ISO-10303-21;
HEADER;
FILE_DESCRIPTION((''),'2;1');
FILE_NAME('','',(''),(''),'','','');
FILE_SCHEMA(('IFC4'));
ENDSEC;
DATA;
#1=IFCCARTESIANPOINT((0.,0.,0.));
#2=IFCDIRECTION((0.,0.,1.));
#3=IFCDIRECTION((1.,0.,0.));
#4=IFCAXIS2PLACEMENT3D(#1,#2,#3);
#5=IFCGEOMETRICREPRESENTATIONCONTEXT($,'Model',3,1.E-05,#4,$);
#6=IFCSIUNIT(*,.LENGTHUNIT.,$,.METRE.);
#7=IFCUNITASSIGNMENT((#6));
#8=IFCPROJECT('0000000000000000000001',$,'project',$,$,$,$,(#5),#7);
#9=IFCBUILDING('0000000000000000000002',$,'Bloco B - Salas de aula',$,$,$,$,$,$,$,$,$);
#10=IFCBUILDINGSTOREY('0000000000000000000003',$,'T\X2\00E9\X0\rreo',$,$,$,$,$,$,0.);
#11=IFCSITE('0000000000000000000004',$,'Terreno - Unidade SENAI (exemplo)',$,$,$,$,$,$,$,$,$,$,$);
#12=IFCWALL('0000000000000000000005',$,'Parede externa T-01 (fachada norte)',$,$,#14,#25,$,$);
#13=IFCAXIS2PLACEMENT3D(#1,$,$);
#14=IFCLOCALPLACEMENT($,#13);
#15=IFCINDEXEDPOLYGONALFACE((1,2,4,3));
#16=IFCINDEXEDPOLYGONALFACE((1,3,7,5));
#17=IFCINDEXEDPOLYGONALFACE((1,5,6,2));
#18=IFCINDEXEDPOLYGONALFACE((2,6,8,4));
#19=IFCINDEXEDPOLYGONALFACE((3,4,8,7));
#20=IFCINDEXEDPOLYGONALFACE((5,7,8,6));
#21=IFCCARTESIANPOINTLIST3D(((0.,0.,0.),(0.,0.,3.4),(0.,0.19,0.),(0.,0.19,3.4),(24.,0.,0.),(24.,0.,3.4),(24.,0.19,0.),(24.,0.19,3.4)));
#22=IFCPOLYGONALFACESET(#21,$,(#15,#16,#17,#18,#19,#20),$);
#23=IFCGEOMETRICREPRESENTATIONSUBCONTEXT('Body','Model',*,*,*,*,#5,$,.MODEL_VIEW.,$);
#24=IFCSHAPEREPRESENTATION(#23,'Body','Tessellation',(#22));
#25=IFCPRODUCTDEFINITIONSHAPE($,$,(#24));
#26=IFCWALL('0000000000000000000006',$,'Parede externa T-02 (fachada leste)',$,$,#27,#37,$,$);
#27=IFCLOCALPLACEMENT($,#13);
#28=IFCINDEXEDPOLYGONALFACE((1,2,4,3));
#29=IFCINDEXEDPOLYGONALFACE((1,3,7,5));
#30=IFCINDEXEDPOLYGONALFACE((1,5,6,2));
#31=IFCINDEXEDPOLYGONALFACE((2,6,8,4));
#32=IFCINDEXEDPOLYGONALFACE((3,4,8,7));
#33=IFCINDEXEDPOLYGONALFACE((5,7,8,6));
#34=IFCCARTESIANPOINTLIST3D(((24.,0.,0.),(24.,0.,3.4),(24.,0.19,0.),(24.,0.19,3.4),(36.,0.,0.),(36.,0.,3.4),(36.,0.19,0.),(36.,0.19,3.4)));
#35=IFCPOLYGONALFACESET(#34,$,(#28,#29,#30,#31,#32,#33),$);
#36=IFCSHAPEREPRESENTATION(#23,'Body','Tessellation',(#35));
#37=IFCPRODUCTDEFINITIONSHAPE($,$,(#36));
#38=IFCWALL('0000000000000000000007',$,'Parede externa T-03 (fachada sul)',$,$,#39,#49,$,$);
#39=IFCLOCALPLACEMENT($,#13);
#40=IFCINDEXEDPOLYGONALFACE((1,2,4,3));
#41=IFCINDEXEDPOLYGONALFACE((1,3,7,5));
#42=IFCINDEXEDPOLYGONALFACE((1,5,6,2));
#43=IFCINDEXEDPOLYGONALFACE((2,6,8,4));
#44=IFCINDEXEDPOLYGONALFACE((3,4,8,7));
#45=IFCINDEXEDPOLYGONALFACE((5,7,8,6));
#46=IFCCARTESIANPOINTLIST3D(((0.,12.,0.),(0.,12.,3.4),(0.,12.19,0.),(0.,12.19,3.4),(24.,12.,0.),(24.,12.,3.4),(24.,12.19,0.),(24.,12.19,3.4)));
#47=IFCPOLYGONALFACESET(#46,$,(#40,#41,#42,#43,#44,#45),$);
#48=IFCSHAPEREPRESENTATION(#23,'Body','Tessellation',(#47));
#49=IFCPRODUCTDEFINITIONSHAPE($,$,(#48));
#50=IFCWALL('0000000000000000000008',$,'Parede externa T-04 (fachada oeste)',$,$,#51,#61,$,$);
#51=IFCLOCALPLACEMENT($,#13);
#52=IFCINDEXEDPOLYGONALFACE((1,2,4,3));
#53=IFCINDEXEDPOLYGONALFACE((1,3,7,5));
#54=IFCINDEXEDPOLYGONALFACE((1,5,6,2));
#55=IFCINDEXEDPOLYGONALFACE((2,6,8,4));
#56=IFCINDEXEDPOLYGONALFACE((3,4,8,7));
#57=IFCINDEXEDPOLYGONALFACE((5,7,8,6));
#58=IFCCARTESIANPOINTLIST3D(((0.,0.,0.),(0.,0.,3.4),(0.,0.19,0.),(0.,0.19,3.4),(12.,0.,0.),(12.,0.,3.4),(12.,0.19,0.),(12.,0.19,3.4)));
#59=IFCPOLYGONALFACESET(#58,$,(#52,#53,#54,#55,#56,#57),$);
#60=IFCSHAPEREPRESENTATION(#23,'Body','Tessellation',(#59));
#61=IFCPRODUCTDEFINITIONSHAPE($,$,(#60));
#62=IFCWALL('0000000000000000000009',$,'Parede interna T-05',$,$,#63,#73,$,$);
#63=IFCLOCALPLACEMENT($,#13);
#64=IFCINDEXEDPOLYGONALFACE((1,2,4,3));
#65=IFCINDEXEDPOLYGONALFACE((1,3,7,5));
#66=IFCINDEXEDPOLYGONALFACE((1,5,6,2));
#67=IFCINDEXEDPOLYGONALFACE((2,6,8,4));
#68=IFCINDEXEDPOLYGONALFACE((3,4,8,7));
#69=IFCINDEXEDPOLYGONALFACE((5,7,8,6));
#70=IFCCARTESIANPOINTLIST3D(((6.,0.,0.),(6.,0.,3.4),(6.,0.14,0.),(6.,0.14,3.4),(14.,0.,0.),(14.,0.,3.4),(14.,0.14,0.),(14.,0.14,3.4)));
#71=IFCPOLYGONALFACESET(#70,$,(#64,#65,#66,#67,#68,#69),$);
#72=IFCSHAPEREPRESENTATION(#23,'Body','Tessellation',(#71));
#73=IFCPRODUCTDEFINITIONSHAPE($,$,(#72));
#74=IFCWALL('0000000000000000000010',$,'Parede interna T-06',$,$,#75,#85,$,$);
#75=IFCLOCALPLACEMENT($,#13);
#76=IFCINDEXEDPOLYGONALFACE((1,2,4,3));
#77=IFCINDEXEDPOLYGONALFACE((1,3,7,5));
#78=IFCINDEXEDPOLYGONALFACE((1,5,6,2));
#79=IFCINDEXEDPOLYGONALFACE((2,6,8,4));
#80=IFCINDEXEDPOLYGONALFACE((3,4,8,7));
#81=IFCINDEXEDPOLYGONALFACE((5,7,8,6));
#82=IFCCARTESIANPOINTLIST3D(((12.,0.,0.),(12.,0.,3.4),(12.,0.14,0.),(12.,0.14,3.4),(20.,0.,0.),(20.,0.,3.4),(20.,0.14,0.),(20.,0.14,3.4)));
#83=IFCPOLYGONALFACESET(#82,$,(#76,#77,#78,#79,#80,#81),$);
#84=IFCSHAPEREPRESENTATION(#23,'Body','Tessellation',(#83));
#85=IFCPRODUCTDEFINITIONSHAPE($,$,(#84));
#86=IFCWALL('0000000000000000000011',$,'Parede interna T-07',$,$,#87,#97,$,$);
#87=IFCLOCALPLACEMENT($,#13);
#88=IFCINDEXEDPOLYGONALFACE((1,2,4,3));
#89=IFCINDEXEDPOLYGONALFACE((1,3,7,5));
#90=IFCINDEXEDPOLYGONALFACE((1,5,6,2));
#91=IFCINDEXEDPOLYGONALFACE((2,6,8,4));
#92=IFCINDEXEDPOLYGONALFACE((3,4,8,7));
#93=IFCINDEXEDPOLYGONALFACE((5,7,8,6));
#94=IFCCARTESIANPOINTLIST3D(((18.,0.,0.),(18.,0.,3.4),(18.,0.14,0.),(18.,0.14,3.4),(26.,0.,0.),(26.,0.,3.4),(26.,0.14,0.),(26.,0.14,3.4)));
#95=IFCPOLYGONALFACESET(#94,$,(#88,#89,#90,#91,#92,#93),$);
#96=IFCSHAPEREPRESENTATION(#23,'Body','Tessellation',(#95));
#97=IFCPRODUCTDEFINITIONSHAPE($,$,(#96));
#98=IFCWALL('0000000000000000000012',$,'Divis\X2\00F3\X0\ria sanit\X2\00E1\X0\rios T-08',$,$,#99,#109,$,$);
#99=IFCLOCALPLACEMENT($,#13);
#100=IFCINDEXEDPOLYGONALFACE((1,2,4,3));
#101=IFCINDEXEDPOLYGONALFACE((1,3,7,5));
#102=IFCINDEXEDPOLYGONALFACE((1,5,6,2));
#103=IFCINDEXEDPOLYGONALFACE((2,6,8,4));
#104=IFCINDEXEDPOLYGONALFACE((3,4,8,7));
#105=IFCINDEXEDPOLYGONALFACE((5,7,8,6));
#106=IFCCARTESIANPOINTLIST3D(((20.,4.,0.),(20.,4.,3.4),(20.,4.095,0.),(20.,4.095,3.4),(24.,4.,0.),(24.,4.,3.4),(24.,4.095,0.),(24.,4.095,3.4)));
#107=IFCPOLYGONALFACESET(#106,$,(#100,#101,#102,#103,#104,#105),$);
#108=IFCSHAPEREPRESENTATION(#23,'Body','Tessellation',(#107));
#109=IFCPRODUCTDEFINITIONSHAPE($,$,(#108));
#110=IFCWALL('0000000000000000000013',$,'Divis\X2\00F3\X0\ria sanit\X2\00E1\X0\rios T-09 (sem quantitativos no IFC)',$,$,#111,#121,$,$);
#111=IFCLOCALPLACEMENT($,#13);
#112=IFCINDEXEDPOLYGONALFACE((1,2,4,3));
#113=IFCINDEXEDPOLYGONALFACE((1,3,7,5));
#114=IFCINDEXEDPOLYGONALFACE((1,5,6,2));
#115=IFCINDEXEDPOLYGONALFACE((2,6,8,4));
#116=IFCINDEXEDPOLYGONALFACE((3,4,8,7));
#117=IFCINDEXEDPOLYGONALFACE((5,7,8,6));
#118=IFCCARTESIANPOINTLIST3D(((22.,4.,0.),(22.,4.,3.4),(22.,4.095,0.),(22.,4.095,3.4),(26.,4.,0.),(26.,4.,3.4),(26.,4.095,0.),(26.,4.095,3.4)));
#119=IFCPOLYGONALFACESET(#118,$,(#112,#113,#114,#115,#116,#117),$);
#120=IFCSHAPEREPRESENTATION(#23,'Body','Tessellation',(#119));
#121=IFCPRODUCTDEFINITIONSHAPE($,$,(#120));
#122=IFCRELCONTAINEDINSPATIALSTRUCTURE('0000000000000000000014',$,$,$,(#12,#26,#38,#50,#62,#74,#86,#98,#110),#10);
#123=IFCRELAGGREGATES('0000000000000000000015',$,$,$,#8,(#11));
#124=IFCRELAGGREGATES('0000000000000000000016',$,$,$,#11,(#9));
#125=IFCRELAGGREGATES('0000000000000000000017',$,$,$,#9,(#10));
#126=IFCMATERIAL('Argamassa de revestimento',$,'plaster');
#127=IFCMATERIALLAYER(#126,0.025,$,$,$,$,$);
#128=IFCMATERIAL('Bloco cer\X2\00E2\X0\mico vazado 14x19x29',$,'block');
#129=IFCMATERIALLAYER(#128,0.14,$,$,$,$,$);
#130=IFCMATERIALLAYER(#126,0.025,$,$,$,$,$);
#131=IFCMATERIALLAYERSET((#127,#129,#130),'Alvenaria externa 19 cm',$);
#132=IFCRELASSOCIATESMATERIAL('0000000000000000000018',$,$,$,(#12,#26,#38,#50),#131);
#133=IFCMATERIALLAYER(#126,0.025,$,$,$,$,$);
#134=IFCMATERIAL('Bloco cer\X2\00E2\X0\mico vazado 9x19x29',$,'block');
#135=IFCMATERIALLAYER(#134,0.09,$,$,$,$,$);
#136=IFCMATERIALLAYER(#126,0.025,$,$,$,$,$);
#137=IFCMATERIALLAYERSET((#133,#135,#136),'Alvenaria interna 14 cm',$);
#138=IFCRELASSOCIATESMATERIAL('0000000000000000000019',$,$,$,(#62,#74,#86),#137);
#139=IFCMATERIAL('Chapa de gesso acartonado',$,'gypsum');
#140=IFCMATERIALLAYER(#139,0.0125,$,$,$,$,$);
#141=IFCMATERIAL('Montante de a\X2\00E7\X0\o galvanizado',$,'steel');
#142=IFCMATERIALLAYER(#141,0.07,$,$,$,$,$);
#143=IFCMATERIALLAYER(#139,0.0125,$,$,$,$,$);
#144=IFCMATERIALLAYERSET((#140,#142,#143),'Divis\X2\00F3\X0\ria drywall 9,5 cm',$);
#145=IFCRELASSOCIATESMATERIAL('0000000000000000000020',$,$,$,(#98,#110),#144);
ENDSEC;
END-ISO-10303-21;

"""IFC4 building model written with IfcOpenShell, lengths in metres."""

from ifc_helpers import new_model, si_unit, frame, origin_with_axes, place, context, subcontext, project, spatial, indexed_curve, outline, extrude, material, layer, layer_set, layer_usage, element, save


model = new_model("IFC4")

# Units and contexts
model_context = context("Model", 3, precision=1e-05, world=origin_with_axes())
body_context = subcontext(model_context, "Body", "Model", "MODEL_VIEW")
ifc_project = project(units=[si_unit("LENGTHUNIT", "METRE")], contexts=[model_context])

# Site, building, storey
site = spatial("IfcSite", under=ifc_project, Name="Terreno - Unidade SENAI (exemplo)")
building = spatial("IfcBuilding", under=site, Name="Bloco B - Salas de aula")
storey = spatial("IfcBuildingStorey", under=building, Name="Térreo", Elevation=0.0)

# Walls
ifc_material_1 = material(Name="Argamassa de revestimento", Category="plaster")
ifc_layer_1 = layer(ifc_material_1, 0.025)
ifc_material_2 = material(Name="Bloco cerâmico vazado 14x19x29", Category="block")
ifc_layer_2 = layer(ifc_material_2, 0.14)
ifc_layer_3 = layer(ifc_material_1, 0.025)
ifc_layer_set_1 = layer_set([ifc_layer_1, ifc_layer_2, ifc_layer_3], Name="Alvenaria externa 19 cm")
ifc_layer_usage_1 = layer_usage(ifc_layer_set_1, "AXIS2", "POSITIVE", 0.0)
wall_1_placement = place(None, origin_with_axes())
element("IfcWall", 1, at=wall_1_placement, inside=storey, material=ifc_layer_usage_1, Name="Parede externa T-01 (fachada norte)", context=body_context, shape_type="SweptSolid", body=[
    extrude(outline(indexed_curve([(0.0, 0.0), (0.0, 0.19), (24.0, 0.19), (24.0, 0.0), (0.0, 0.0)], self_intersect=False)), origin_with_axes(), (0.0, 0.0, 1.0), 3.4),
])
ifc_layer_usage_2 = layer_usage(ifc_layer_set_1, "AXIS2", "POSITIVE", 0.0)
wall_2_placement = place(None, frame((24.0, 0.0, 0.0), z_axis=(0.0, 0.0, 1.0), x_axis=(1.0, 0.0, 0.0)))
element("IfcWall", 2, at=wall_2_placement, inside=storey, material=ifc_layer_usage_2, Name="Parede externa T-02 (fachada leste)", context=body_context, shape_type="SweptSolid", body=[
    extrude(outline(indexed_curve([(0.0, 0.0), (0.0, 0.19), (12.0, 0.19), (12.0, 0.0), (0.0, 0.0)], self_intersect=False)), origin_with_axes(), (0.0, 0.0, 1.0), 3.4),
])
ifc_layer_usage_3 = layer_usage(ifc_layer_set_1, "AXIS2", "POSITIVE", 0.0)
wall_3_placement = place(None, frame((0.0, 12.0, 0.0), z_axis=(0.0, 0.0, 1.0), x_axis=(1.0, 0.0, 0.0)))
element("IfcWall", 3, at=wall_3_placement, inside=storey, material=ifc_layer_usage_3, Name="Parede externa T-03 (fachada sul)", context=body_context, shape_type="SweptSolid", body=[
    extrude(outline(indexed_curve([(0.0, 0.0), (0.0, 0.19), (24.0, 0.19), (24.0, 0.0), (0.0, 0.0)], self_intersect=False)), origin_with_axes(), (0.0, 0.0, 1.0), 3.4),
])
ifc_layer_usage_4 = layer_usage(ifc_layer_set_1, "AXIS2", "POSITIVE", 0.0)
wall_4_placement = place(None, origin_with_axes())
element("IfcWall", 4, at=wall_4_placement, inside=storey, material=ifc_layer_usage_4, Name="Parede externa T-04 (fachada oeste)", context=body_context, shape_type="SweptSolid", body=[
    extrude(outline(indexed_curve([(0.0, 0.0), (0.0, 0.19), (12.0, 0.19), (12.0, 0.0), (0.0, 0.0)], self_intersect=False)), origin_with_axes(), (0.0, 0.0, 1.0), 3.4),
])
ifc_layer_4 = layer(ifc_material_1, 0.025)
ifc_material_3 = material(Name="Bloco cerâmico vazado 9x19x29", Category="block")
ifc_layer_5 = layer(ifc_material_3, 0.09)
ifc_layer_6 = layer(ifc_material_1, 0.025)
ifc_layer_set_2 = layer_set([ifc_layer_4, ifc_layer_5, ifc_layer_6], Name="Alvenaria interna 14 cm")
ifc_layer_usage_5 = layer_usage(ifc_layer_set_2, "AXIS2", "POSITIVE", 0.0)
wall_5_placement = place(None, frame((6.0, 0.0, 0.0), z_axis=(0.0, 0.0, 1.0), x_axis=(1.0, 0.0, 0.0)))
element("IfcWall", 5, at=wall_5_placement, inside=storey, material=ifc_layer_usage_5, Name="Parede interna T-05", context=body_context, shape_type="SweptSolid", body=[
    extrude(outline(indexed_curve([(0.0, 0.0), (0.0, 0.14), (8.0, 0.14), (8.0, 0.0), (0.0, 0.0)], self_intersect=False)), origin_with_axes(), (0.0, 0.0, 1.0), 3.4),
])
ifc_layer_usage_6 = layer_usage(ifc_layer_set_2, "AXIS2", "POSITIVE", 0.0)
wall_6_placement = place(None, frame((12.0, 0.0, 0.0), z_axis=(0.0, 0.0, 1.0), x_axis=(1.0, 0.0, 0.0)))
element("IfcWall", 6, at=wall_6_placement, inside=storey, material=ifc_layer_usage_6, Name="Parede interna T-06", context=body_context, shape_type="SweptSolid", body=[
    extrude(outline(indexed_curve([(0.0, 0.0), (0.0, 0.14), (8.0, 0.14), (8.0, 0.0), (0.0, 0.0)], self_intersect=False)), origin_with_axes(), (0.0, 0.0, 1.0), 3.4),
])
ifc_layer_usage_7 = layer_usage(ifc_layer_set_2, "AXIS2", "POSITIVE", 0.0)
wall_7_placement = place(None, frame((18.0, 0.0, 0.0), z_axis=(0.0, 0.0, 1.0), x_axis=(1.0, 0.0, 0.0)))
element("IfcWall", 7, at=wall_7_placement, inside=storey, material=ifc_layer_usage_7, Name="Parede interna T-07", context=body_context, shape_type="SweptSolid", body=[
    extrude(outline(indexed_curve([(0.0, 0.0), (0.0, 0.14), (8.0, 0.14), (8.0, 0.0), (0.0, 0.0)], self_intersect=False)), origin_with_axes(), (0.0, 0.0, 1.0), 3.4),
])
ifc_material_4 = material(Name="Chapa de gesso acartonado", Category="gypsum")
ifc_layer_7 = layer(ifc_material_4, 0.0125)
ifc_material_5 = material(Name="Montante de aço galvanizado", Category="steel")
ifc_layer_8 = layer(ifc_material_5, 0.07)
ifc_layer_9 = layer(ifc_material_4, 0.0125)
ifc_layer_set_3 = layer_set([ifc_layer_7, ifc_layer_8, ifc_layer_9], Name="Divisória drywall 9,5 cm")
ifc_layer_usage_8 = layer_usage(ifc_layer_set_3, "AXIS2", "POSITIVE", 0.0)
wall_8_placement = place(None, frame((20.0, 4.0, 0.0), z_axis=(0.0, 0.0, 1.0), x_axis=(1.0, 0.0, 0.0)))
element("IfcWall", 8, at=wall_8_placement, inside=storey, material=ifc_layer_usage_8, Name="Divisória sanitários T-08", context=body_context, shape_type="SweptSolid", body=[
    extrude(outline(indexed_curve([(0.0, 0.0), (0.0, 0.095), (4.0, 0.095), (4.0, 0.0), (0.0, 0.0)], self_intersect=False)), origin_with_axes(), (0.0, 0.0, 1.0), 3.4),
])
ifc_layer_usage_9 = layer_usage(ifc_layer_set_3, "AXIS2", "POSITIVE", 0.0)
wall_9_placement = place(None, frame((22.0, 4.0, 0.0), z_axis=(0.0, 0.0, 1.0), x_axis=(1.0, 0.0, 0.0)))
element("IfcWall", 9, at=wall_9_placement, inside=storey, material=ifc_layer_usage_9, Name="Divisória sanitários T-09 (sem quantitativos no IFC)", context=body_context, shape_type="SweptSolid", body=[
    extrude(outline(indexed_curve([(0.0, 0.0), (0.0, 0.095), (4.0, 0.095), (4.0, 0.0), (0.0, 0.0)], self_intersect=False)), origin_with_axes(), (0.0, 0.0, 1.0), 3.4),
])

save(model, "model.ifc")
